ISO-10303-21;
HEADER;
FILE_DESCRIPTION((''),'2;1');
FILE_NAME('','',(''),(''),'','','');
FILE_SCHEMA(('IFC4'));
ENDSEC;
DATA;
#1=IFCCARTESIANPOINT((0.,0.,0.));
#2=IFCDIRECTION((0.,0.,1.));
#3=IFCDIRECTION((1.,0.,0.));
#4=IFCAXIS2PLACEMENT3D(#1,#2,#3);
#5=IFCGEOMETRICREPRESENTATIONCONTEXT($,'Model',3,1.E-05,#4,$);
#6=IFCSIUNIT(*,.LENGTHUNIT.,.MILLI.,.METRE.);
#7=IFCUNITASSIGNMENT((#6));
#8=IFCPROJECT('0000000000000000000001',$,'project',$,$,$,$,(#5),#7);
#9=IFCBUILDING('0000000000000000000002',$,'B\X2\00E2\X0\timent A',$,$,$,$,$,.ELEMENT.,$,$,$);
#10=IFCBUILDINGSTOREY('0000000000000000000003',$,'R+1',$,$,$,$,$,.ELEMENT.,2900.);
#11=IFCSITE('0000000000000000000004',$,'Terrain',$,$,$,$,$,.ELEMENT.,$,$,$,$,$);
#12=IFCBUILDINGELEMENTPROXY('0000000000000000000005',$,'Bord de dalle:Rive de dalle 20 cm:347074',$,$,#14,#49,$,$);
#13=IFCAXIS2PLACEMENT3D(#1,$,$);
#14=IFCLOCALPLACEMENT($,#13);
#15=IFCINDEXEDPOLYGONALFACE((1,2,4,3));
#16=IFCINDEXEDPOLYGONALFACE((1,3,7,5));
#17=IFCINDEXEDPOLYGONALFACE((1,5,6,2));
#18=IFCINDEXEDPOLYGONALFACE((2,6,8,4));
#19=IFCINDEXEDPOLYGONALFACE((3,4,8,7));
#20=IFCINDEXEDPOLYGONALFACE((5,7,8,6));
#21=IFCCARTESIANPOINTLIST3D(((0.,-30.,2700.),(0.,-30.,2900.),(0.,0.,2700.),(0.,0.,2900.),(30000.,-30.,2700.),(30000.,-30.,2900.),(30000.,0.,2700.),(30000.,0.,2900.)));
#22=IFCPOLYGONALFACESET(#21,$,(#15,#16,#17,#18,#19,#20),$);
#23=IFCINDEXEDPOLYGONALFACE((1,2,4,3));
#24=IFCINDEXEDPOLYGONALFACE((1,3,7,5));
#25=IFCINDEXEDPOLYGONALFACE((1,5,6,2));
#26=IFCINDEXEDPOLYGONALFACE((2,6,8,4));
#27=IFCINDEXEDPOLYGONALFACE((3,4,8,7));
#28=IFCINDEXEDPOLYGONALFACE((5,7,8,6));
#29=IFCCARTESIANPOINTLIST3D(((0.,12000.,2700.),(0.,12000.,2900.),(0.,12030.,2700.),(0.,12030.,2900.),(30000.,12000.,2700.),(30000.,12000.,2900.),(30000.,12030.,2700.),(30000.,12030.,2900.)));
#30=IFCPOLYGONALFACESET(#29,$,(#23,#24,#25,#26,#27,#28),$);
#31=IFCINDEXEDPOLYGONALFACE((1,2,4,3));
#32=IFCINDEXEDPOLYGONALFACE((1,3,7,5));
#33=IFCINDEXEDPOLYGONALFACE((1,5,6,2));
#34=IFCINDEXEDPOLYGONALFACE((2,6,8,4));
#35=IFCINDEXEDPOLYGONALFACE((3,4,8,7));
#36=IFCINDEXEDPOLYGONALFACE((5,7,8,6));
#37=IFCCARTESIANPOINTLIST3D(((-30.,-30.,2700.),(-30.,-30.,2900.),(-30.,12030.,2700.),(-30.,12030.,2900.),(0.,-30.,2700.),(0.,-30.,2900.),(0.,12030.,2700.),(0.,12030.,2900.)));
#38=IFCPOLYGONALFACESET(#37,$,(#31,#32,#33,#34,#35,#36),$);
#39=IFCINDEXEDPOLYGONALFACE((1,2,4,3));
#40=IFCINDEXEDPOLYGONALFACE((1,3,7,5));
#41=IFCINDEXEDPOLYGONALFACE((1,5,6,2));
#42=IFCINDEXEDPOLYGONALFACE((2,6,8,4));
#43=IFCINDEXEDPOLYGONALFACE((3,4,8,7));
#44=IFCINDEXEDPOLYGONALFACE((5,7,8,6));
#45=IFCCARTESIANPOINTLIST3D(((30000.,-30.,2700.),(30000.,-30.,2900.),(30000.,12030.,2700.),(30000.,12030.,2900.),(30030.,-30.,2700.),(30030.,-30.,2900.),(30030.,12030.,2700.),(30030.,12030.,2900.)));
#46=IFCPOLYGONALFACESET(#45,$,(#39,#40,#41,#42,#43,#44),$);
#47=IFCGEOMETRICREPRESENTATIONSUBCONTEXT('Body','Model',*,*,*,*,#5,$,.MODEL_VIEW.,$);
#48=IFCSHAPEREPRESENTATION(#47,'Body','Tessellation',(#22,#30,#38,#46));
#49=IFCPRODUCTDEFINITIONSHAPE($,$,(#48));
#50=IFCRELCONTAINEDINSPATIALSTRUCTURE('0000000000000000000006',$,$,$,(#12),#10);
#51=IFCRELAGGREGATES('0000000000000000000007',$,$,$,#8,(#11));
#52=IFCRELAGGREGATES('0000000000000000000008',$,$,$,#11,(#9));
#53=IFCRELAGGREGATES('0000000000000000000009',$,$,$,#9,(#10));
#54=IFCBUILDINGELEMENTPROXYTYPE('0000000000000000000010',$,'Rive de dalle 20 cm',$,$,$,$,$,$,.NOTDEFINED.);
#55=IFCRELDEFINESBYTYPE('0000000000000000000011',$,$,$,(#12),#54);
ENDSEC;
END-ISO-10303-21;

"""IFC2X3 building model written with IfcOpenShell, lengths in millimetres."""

from ifc_helpers import new_model, si_unit, frame, frame_2d, origin_with_axes, place, context, subcontext, project, spatial, rectangle, extrude, type_object, element, save


model = new_model("IFC2X3")

# Units and contexts
model_context = context("Model", 3, precision=1e-05, world=origin_with_axes())
body_context = subcontext(model_context, "Body", "Model", "MODEL_VIEW")
ifc_project = project(units=[si_unit("LENGTHUNIT", "METRE", prefix="MILLI")], contexts=[model_context])

# Site, building, storey
site = spatial("IfcSite", under=ifc_project, Name="Terrain", CompositionType="ELEMENT")
building = spatial("IfcBuilding", under=site, Name="Bâtiment A", CompositionType="ELEMENT")
storey = spatial("IfcBuildingStorey", under=building, Name="R+1", CompositionType="ELEMENT", Elevation=2900.0)

# Building element proxy
building_element_proxy_type = type_object("IfcBuildingElementProxyType", Name="Rive de dalle 20 cm", PredefinedType="NOTDEFINED")
proxy_placement = place(None, origin_with_axes())
element("IfcBuildingElementProxy", 1, at=proxy_placement, inside=storey, type_object=building_element_proxy_type, Name="Bord de dalle:Rive de dalle 20 cm:347074", context=body_context, shape_type="SweptSolid", body=[
    extrude(rectangle(XDim=30000.0, YDim=30.0, at=frame_2d((15000.0, -15.0))), frame((0.0, 0.0, 2700.0), z_axis=(0.0, 0.0, 1.0), x_axis=(1.0, 0.0, 0.0)), (0.0, 0.0, 1.0), 200.0),
    extrude(rectangle(XDim=30000.0, YDim=30.0, at=frame_2d((15000.0, 12015.0))), frame((0.0, 0.0, 2700.0), z_axis=(0.0, 0.0, 1.0), x_axis=(1.0, 0.0, 0.0)), (0.0, 0.0, 1.0), 200.0),
    extrude(rectangle(XDim=30.0, YDim=12060.0, at=frame_2d((-15.0, 6000.0))), frame((0.0, 0.0, 2700.0), z_axis=(0.0, 0.0, 1.0), x_axis=(1.0, 0.0, 0.0)), (0.0, 0.0, 1.0), 200.0),
    extrude(rectangle(XDim=30.0, YDim=12060.0, at=frame_2d((30015.0, 6000.0))), frame((0.0, 0.0, 2700.0), z_axis=(0.0, 0.0, 1.0), x_axis=(1.0, 0.0, 0.0)), (0.0, 0.0, 1.0), 200.0),
])

save(model, "model.ifc")
